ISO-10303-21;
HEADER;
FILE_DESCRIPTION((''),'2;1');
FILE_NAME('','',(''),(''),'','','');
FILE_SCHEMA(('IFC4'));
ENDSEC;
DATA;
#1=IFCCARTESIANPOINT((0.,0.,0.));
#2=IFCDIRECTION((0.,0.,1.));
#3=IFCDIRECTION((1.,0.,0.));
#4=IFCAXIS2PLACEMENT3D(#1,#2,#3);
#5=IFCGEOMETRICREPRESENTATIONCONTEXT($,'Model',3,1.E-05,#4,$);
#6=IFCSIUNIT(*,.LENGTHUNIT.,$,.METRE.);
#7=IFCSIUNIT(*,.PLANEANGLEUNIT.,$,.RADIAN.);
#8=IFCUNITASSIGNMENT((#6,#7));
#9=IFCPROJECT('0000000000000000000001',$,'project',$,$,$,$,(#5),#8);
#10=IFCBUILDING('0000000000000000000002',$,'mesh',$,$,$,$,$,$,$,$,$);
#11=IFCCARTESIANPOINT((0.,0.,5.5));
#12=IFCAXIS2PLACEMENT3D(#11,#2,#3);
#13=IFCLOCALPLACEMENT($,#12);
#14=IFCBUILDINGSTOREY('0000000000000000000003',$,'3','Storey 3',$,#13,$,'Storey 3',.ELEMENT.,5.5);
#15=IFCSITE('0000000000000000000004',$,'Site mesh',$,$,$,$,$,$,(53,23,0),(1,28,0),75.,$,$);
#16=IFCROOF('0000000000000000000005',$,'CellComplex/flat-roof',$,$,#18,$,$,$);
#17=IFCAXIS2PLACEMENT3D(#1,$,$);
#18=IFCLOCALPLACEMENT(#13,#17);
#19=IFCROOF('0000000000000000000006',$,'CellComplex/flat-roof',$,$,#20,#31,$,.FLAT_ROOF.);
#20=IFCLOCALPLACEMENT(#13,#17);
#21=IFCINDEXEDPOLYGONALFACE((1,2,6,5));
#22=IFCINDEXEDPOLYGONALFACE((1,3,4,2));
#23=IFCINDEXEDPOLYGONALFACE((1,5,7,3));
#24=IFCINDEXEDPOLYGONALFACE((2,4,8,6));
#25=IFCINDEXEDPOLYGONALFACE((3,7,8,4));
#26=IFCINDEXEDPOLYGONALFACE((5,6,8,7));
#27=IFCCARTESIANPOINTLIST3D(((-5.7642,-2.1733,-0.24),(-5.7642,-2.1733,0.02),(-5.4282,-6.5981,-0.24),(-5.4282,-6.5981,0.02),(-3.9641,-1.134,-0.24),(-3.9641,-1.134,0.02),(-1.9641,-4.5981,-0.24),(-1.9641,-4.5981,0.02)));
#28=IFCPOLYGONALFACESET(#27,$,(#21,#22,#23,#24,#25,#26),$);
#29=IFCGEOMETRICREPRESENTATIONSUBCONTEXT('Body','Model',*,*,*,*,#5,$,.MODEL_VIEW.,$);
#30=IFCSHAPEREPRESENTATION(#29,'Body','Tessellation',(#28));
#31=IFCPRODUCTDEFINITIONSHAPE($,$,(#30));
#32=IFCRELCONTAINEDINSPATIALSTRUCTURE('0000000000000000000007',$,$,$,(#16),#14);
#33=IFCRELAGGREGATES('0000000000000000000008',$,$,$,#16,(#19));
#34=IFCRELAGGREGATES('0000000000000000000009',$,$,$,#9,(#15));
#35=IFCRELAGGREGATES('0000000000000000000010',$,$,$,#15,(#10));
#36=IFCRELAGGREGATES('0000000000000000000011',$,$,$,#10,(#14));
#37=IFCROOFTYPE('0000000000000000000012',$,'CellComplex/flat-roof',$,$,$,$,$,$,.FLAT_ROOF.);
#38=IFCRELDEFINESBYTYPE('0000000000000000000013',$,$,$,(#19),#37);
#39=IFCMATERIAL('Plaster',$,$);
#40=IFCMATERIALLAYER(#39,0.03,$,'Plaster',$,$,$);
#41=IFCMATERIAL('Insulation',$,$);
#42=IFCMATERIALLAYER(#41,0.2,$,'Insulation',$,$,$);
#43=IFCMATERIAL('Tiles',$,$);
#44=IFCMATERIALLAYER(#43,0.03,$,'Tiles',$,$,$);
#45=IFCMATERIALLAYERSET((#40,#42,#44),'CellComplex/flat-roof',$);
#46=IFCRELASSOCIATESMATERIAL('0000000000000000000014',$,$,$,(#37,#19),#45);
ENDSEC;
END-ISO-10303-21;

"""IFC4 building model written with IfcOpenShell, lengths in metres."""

from ifc_helpers import new_model, si_unit, frame, origin, origin_with_axes, place, context, subcontext, project, spatial, polyline, outline, extrude, material, layer, layer_set, layer_usage, type_object, element, aggregate, save


model = new_model("IFC4")

# Units and contexts
model_context = context("Model", 3, precision=1e-05, world=origin_with_axes())
body_context = subcontext(model_context, "Body", "Model", "MODEL_VIEW")
ifc_project = project(units=[si_unit("LENGTHUNIT", "METRE"), si_unit("PLANEANGLEUNIT", "RADIAN")], contexts=[model_context])

# Site, building, storey
site = spatial("IfcSite", under=ifc_project, Name="Site mesh", RefLatitude=(53, 23, 0), RefLongitude=(1, 28, 0), RefElevation=75.0)
building = spatial("IfcBuilding", under=site, Name="mesh")
storey_placement = place(None, frame((0.0, 0.0, 5.5), z_axis=(0.0, 0.0, 1.0), x_axis=(1.0, 0.0, 0.0)))
storey = spatial("IfcBuildingStorey", under=building, at=storey_placement, Name="3", Description="Storey 3", LongName="Storey 3", CompositionType="ELEMENT", Elevation=5.5)

# Roofs
roof_1_placement = place(storey_placement, frame((0.0, 0.0, -5.5), z_axis=(0.0, 0.0, 1.0), x_axis=(1.0, 0.0, 0.0)))
roof_1 = element("IfcRoof", 1, at=roof_1_placement, inside=storey, Name="CellComplex/flat-roof")
ifc_material_1 = material(Name="Plaster")
ifc_layer_1 = layer(ifc_material_1, 0.03, Name="Plaster")
ifc_material_2 = material(Name="Insulation")
ifc_layer_2 = layer(ifc_material_2, 0.2, Name="Insulation")
ifc_material_3 = material(Name="Tiles")
ifc_layer_3 = layer(ifc_material_3, 0.03, Name="Tiles")
ifc_layer_set = layer_set([ifc_layer_1, ifc_layer_2, ifc_layer_3], Name="CellComplex/flat-roof")
ifc_layer_usage = layer_usage(ifc_layer_set, "AXIS3", "POSITIVE", 0.0)
roof_type = type_object("IfcRoofType", Name="CellComplex/flat-roof", PredefinedType="FLAT_ROOF", material=ifc_layer_set)
roof_2_placement = place(roof_1_placement, frame((-5.7642, -2.1733, 5.26), z_axis=(0.0, 0.0, 1.0), x_axis=(0.0, 1.0, 0.0)))
roof_2 = element("IfcRoof", 2, at=roof_2_placement, type_object=roof_type, material=ifc_layer_usage, Name="CellComplex/flat-roof", PredefinedType="FLAT_ROOF", context=body_context, shape_type="SweptSolid", body=[
    extrude(outline(polyline([(0.0, 0.0), (-4.4248, -0.336), (-2.4248, -3.8001), (1.0393, -1.8001), (0.0, 0.0)])), origin(), (0.0, 0.0, 1.0), 0.26),
])
aggregate(roof_1, [roof_2])

save(model, "model.ifc")
